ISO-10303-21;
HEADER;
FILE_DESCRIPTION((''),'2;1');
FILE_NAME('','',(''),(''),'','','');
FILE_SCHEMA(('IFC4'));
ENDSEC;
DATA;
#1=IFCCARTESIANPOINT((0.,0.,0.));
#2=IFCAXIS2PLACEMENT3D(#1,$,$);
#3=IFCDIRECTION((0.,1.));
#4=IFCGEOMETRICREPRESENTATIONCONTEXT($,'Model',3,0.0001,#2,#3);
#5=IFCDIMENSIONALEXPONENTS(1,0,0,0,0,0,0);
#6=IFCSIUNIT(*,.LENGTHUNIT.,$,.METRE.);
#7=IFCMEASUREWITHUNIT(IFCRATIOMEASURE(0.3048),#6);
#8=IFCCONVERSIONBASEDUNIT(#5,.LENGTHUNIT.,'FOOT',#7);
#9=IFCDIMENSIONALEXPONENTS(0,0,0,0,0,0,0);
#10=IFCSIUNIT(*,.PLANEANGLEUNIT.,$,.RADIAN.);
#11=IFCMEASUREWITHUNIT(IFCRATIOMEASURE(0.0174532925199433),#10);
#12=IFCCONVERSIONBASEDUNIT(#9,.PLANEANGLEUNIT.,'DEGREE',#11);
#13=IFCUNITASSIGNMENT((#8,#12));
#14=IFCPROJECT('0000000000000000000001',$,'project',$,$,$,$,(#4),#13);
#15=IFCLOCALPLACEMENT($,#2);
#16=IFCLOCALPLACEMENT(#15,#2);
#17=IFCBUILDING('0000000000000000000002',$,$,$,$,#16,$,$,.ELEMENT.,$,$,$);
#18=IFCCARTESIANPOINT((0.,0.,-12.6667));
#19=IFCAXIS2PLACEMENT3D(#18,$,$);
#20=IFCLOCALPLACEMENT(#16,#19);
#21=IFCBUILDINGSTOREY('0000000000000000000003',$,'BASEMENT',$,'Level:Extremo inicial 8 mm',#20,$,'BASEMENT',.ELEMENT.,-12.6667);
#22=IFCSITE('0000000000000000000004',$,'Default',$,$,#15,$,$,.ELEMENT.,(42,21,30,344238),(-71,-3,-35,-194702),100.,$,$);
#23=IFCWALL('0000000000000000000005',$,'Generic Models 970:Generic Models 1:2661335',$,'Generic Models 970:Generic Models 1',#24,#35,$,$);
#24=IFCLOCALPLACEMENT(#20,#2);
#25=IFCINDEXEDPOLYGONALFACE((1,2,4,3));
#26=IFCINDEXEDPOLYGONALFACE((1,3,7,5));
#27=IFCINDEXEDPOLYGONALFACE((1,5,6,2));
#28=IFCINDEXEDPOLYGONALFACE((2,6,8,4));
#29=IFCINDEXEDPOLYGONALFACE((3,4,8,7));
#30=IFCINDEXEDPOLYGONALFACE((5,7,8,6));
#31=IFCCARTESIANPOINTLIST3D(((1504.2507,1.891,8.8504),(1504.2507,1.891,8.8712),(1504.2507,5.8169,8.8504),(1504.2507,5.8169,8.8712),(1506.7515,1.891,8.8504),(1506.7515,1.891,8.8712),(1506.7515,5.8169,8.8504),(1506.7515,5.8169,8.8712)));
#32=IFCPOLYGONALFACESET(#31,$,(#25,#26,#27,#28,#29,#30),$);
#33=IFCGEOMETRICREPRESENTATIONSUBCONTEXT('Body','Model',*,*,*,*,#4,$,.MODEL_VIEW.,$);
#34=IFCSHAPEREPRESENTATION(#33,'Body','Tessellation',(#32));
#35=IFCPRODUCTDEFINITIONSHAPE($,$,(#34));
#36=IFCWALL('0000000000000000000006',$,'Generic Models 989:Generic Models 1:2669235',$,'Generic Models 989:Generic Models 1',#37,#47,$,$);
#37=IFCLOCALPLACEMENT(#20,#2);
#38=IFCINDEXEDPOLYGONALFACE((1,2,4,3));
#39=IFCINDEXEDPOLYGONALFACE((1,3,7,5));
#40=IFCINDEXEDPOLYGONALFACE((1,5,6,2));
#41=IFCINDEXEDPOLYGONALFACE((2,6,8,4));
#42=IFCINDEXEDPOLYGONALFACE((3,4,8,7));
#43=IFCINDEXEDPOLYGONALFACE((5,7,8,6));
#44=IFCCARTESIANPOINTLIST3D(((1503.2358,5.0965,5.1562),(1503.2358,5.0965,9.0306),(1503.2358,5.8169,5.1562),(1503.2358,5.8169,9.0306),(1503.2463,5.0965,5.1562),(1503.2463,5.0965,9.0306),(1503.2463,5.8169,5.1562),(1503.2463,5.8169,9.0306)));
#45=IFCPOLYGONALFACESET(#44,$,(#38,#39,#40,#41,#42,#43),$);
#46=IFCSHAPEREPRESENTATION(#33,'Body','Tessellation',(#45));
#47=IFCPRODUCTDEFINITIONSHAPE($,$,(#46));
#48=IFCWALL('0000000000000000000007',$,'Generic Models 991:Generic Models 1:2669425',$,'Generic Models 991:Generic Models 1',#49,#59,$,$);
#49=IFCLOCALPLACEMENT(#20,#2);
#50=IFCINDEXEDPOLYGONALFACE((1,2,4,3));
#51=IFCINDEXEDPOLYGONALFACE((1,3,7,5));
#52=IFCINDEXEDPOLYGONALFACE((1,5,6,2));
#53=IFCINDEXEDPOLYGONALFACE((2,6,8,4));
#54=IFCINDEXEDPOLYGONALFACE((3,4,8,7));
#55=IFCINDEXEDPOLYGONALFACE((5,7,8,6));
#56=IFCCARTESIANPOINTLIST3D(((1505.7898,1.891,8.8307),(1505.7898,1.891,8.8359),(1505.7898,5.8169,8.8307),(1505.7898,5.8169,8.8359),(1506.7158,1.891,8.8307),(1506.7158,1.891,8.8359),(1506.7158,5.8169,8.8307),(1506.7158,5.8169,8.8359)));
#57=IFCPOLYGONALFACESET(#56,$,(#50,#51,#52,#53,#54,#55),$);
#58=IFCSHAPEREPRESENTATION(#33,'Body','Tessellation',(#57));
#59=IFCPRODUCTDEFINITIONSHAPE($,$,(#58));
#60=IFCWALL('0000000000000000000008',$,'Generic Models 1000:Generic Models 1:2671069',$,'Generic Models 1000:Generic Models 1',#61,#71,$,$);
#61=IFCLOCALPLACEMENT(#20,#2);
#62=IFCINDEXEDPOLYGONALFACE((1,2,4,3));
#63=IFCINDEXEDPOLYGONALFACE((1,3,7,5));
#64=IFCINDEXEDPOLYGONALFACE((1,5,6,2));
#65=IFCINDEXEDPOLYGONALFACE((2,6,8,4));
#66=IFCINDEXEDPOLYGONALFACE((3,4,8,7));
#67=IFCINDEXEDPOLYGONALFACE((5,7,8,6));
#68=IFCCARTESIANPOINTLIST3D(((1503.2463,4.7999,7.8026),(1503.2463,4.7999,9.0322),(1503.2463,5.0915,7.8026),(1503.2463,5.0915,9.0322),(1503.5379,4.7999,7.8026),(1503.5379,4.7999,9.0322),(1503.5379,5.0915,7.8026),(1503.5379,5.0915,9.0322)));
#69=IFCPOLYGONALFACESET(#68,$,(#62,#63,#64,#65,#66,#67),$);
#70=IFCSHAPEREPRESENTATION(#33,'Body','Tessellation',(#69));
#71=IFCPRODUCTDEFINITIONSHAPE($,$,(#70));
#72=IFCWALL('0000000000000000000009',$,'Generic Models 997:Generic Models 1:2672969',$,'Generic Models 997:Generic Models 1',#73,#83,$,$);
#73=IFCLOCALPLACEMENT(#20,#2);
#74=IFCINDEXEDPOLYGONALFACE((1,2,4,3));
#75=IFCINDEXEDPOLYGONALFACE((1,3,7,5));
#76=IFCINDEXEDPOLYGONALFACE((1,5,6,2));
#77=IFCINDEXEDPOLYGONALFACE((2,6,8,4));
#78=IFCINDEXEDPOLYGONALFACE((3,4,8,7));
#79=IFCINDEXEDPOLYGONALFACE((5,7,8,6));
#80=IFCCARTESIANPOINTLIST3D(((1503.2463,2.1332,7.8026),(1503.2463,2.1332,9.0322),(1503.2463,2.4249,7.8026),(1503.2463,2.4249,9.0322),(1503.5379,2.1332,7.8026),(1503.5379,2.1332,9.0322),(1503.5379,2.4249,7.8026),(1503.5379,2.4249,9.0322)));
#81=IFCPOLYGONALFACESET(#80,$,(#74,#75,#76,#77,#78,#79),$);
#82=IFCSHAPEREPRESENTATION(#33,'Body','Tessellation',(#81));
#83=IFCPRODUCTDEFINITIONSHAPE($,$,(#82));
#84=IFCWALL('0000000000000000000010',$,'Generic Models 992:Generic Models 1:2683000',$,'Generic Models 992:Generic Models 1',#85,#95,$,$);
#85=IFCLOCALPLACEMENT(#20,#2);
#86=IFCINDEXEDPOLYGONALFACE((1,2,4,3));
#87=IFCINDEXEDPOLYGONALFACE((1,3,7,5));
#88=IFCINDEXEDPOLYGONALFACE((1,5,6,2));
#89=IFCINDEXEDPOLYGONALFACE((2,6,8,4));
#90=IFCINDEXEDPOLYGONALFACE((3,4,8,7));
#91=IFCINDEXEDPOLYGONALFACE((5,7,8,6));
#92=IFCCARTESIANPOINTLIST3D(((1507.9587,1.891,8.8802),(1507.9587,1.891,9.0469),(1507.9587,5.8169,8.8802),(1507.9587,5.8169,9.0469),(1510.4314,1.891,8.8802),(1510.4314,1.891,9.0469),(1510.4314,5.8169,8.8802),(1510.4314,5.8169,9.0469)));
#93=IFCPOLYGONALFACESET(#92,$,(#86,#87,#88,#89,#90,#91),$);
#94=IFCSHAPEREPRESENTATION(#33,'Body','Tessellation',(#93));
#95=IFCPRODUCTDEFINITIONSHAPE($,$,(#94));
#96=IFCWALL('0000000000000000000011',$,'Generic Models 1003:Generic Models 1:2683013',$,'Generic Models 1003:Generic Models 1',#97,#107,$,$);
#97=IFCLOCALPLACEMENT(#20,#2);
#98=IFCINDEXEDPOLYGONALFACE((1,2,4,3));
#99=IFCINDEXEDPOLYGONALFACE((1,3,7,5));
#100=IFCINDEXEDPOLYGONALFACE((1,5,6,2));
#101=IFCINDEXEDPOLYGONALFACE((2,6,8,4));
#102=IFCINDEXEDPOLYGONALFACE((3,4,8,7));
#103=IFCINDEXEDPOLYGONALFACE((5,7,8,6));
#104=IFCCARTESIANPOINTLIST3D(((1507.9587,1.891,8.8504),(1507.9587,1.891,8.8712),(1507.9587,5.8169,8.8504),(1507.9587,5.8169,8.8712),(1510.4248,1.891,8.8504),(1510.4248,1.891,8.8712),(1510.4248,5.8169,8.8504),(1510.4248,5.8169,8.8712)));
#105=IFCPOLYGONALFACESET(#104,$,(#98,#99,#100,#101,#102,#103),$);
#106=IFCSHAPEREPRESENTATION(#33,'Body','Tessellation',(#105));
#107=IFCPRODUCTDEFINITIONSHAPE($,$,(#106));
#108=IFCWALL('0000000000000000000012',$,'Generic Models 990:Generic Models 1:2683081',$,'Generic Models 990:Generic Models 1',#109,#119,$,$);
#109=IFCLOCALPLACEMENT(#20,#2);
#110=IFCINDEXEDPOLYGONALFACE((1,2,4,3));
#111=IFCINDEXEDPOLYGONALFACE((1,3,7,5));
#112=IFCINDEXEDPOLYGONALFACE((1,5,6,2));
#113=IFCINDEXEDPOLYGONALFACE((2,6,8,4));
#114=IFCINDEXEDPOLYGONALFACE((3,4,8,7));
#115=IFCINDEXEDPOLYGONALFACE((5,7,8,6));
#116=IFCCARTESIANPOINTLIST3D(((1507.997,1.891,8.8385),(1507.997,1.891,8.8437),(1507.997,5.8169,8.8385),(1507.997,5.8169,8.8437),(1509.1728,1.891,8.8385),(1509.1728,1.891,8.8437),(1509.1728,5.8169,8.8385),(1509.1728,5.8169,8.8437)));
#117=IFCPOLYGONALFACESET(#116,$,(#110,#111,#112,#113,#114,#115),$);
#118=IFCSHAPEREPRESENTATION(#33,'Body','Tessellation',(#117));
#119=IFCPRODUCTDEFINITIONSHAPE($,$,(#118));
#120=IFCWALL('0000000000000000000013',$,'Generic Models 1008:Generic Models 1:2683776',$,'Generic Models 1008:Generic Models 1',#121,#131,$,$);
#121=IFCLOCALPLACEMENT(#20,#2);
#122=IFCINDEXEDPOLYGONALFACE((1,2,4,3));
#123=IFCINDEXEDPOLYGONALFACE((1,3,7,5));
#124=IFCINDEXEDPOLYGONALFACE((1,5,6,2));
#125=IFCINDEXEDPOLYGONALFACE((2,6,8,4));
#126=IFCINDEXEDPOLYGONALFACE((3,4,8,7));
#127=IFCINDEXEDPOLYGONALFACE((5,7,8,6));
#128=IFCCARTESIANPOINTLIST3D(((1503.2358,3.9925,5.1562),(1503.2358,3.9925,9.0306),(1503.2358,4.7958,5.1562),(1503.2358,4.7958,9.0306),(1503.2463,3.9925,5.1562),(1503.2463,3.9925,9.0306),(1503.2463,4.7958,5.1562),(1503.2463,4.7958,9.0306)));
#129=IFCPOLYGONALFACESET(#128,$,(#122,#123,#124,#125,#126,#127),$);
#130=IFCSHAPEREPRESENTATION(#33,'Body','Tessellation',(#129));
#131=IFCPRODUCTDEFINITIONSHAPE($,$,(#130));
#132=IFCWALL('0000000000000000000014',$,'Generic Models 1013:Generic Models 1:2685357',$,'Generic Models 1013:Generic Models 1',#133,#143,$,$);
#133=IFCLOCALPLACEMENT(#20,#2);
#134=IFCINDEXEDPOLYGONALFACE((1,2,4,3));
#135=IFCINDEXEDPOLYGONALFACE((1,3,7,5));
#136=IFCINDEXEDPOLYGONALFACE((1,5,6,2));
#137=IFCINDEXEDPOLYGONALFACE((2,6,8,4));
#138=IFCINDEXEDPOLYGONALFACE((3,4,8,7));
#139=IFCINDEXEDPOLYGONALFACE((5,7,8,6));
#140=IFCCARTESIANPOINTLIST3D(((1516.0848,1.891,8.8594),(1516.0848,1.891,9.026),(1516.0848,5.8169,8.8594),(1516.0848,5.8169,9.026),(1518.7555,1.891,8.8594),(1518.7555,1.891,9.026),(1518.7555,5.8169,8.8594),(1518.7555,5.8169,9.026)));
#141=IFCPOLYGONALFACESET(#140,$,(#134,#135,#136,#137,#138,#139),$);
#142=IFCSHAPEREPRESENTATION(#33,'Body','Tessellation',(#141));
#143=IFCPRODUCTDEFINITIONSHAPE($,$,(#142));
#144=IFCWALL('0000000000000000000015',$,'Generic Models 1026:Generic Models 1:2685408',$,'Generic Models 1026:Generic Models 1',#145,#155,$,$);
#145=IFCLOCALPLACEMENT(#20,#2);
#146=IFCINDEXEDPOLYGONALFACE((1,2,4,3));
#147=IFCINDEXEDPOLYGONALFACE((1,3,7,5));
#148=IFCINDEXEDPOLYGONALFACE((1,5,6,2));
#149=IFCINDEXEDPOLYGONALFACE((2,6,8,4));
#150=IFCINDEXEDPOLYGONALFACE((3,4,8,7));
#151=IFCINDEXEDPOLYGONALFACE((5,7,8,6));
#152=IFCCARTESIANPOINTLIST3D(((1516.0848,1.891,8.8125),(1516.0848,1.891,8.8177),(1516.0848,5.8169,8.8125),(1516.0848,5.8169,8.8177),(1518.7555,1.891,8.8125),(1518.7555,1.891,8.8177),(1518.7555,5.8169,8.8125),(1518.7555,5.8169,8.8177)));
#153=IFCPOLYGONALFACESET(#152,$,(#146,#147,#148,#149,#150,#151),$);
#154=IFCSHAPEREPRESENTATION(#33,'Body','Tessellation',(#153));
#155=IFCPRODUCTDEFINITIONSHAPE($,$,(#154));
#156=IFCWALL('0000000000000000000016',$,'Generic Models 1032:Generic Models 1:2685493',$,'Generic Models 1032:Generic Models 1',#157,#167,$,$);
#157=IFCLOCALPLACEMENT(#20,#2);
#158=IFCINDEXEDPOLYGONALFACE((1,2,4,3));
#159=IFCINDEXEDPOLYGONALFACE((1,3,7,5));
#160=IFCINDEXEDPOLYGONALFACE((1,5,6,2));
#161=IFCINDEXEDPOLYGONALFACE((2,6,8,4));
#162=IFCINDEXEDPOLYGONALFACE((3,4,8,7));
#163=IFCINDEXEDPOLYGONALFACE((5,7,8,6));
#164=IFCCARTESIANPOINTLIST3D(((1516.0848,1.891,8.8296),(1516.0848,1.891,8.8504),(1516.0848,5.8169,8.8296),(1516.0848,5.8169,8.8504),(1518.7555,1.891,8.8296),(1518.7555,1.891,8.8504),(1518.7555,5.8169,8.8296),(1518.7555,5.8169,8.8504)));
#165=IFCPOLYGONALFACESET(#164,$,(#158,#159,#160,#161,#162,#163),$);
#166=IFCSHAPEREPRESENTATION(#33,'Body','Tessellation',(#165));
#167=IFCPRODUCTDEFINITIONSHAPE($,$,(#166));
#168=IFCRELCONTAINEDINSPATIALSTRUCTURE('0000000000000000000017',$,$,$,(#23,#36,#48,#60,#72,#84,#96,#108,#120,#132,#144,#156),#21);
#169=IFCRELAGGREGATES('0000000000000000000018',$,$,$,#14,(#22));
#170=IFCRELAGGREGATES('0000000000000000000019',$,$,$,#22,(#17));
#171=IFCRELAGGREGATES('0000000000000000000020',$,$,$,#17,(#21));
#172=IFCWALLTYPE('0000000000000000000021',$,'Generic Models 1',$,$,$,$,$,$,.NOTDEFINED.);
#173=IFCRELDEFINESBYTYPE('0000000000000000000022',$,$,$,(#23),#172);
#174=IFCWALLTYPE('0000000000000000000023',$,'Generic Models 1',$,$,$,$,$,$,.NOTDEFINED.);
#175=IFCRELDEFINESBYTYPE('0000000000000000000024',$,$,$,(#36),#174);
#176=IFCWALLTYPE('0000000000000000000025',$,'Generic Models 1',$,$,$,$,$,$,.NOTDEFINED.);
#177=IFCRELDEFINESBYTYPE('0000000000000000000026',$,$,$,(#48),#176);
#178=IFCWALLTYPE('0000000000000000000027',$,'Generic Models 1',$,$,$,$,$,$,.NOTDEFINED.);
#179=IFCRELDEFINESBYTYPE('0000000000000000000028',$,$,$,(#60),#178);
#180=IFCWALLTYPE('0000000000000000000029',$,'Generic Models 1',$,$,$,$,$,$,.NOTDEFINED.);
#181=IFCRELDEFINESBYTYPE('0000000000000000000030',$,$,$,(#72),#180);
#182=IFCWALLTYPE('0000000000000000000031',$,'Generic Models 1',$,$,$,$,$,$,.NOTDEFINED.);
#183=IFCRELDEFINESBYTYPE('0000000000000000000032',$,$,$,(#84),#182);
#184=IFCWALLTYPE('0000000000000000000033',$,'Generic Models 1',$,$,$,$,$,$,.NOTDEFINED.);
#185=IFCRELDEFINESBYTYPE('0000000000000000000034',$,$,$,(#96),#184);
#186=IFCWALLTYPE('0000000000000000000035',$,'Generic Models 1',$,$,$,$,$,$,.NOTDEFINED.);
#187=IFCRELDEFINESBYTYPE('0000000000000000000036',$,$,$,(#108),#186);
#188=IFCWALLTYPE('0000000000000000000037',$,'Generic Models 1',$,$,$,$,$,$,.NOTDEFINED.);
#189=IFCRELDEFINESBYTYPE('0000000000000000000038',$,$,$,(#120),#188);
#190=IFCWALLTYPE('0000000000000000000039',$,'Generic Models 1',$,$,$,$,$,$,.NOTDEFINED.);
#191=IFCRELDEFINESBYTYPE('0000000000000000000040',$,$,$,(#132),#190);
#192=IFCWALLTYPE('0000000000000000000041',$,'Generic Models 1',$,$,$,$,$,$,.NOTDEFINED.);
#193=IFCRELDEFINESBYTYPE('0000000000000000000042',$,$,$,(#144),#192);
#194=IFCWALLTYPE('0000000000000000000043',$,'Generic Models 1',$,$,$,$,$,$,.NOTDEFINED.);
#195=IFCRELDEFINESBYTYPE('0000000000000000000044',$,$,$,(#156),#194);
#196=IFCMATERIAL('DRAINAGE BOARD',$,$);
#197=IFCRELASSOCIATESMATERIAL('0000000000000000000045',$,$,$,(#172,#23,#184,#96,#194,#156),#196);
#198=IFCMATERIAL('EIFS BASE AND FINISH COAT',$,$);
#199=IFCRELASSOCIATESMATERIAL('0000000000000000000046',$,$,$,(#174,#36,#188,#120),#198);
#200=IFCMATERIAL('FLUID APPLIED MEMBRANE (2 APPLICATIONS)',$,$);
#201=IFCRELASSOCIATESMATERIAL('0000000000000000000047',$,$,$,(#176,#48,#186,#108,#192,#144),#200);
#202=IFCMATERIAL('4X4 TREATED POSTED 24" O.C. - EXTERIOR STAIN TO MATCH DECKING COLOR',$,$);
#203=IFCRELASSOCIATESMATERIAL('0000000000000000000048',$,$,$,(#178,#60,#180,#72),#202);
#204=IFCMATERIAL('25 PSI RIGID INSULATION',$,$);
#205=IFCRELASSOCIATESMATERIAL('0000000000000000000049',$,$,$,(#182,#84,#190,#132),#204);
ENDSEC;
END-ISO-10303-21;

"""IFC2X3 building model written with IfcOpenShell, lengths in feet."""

from ifc_helpers import new_model, entity, si_unit, converted_unit, direction, frame, frame_2d, origin, place, context, subcontext, project, spatial, rectangle, extrude, material, type_object, element, save


model = new_model("IFC2X3")

# Units and contexts
model_context = context("Model", 3, precision=0.0001, world=origin(), true_north=direction((0.0, 1.0)))
body_context = subcontext(model_context, "Body", "Model", "MODEL_VIEW")
ifc_project = project(units=[converted_unit("LENGTHUNIT", "FOOT", entity("IfcRatioMeasure", 0.3048), si_unit("LENGTHUNIT", "METRE"), dimensions=[1, 0, 0, 0, 0, 0, 0]), converted_unit("PLANEANGLEUNIT", "DEGREE", entity("IfcRatioMeasure", 0.0174532925199433), si_unit("PLANEANGLEUNIT", "RADIAN"), dimensions=[0, 0, 0, 0, 0, 0, 0])], contexts=[model_context])

# Site, building, storey
site_placement = place(None, origin())
site = spatial("IfcSite", under=ifc_project, at=site_placement, Name="Default", CompositionType="ELEMENT", RefLatitude=(42, 21, 30, 344238), RefLongitude=(-71, -3, -35, -194702), RefElevation=100.0)
building_placement = place(site_placement, origin())
building = spatial("IfcBuilding", under=site, at=building_placement, CompositionType="ELEMENT")
storey_placement = place(building_placement, frame((0.0, 0.0, -12.6667)))
storey = spatial("IfcBuildingStorey", under=building, at=storey_placement, Name="BASEMENT", ObjectType="Level:Extremo inicial 8 mm", LongName="BASEMENT", CompositionType="ELEMENT", Elevation=-12.6667)

# Shared definitions
ifc_material_1 = material(Name="25 PSI RIGID INSULATION")
ifc_material_2 = material(Name="FLUID APPLIED MEMBRANE (2 APPLICATIONS)")

# Walls
ifc_material_3 = material(Name="DRAINAGE BOARD")
wall_type_1 = type_object("IfcWallType", Name="Generic Models 1", PredefinedType="NOTDEFINED", material=ifc_material_3)
wall_1_placement = place(storey_placement, frame((1504.2507, 1.891, 8.8504), z_axis=(0.0, 0.0, 1.0), x_axis=(0.0, 1.0, 0.0)))
element("IfcWall", 1, at=wall_1_placement, inside=storey, type_object=wall_type_1, material=ifc_material_3, Name="Generic Models 970:Generic Models 1:2661335", ObjectType="Generic Models 970:Generic Models 1", context=body_context, shape_type="SweptSolid", body=[
    extrude(rectangle(XDim=3.9258, YDim=2.5007, at=frame_2d((0.0, 0.0), x_axis=(1.0, 0.0))), frame((1.9629, -1.2504, 0.0)), (0.0, 0.0, 1.0), 0.0208),
])
ifc_material_4 = material(Name="EIFS BASE AND FINISH COAT")
wall_type_2 = type_object("IfcWallType", Name="Generic Models 1", PredefinedType="NOTDEFINED", material=ifc_material_4)
wall_2_placement = place(storey_placement, frame((1503.2358, 5.0965, 5.1562), z_axis=(0.0, 0.0, 1.0), x_axis=(0.0, 1.0, 0.0)))
element("IfcWall", 2, at=wall_2_placement, inside=storey, type_object=wall_type_2, material=ifc_material_4, Name="Generic Models 989:Generic Models 1:2669235", ObjectType="Generic Models 989:Generic Models 1", context=body_context, shape_type="SweptSolid", body=[
    extrude(rectangle(XDim=0.7204, YDim=0.0104, at=frame_2d((0.0, 0.0), x_axis=(1.0, 0.0))), frame((0.3602, -0.0052, 0.0)), (0.0, 0.0, 1.0), 3.8744),
])
wall_type_3 = type_object("IfcWallType", Name="Generic Models 1", PredefinedType="NOTDEFINED", material=ifc_material_2)
wall_3_placement = place(storey_placement, frame((1505.7898, 1.891, 8.8307), z_axis=(0.0, 0.0, 1.0), x_axis=(0.0, 1.0, 0.0)))
element("IfcWall", 3, at=wall_3_placement, inside=storey, type_object=wall_type_3, material=ifc_material_2, Name="Generic Models 991:Generic Models 1:2669425", ObjectType="Generic Models 991:Generic Models 1", context=body_context, shape_type="SweptSolid", body=[
    extrude(rectangle(XDim=3.9258, YDim=0.9261, at=frame_2d((0.0, 0.0), x_axis=(1.0, 0.0))), frame((1.9629, -0.463, 0.0)), (0.0, 0.0, 1.0), 0.0052),
])
ifc_material_5 = material(Name="4X4 TREATED POSTED 24\" O.C. - EXTERIOR STAIN TO MATCH DECKING COLOR")
wall_type_4 = type_object("IfcWallType", Name="Generic Models 1", PredefinedType="NOTDEFINED", material=ifc_material_5)
wall_4_placement = place(storey_placement, frame((1503.2463, 4.7999, 7.8026)))
element("IfcWall", 4, at=wall_4_placement, inside=storey, type_object=wall_type_4, material=ifc_material_5, Name="Generic Models 1000:Generic Models 1:2671069", ObjectType="Generic Models 1000:Generic Models 1", context=body_context, shape_type="SweptSolid", body=[
    extrude(rectangle(XDim=0.2917, YDim=0.2917, at=frame_2d((0.0, 0.0), x_axis=(1.0, 0.0))), frame((0.1458, 0.1458, 0.0), z_axis=(0.0, 0.0, 1.0), x_axis=(0.0, 1.0, 0.0)), (0.0, 0.0, 1.0), 1.2295),
])
wall_type_5 = type_object("IfcWallType", Name="Generic Models 1", PredefinedType="NOTDEFINED", material=ifc_material_5)
wall_5_placement = place(storey_placement, frame((1503.2463, 2.1332, 7.8026)))
element("IfcWall", 5, at=wall_5_placement, inside=storey, type_object=wall_type_5, material=ifc_material_5, Name="Generic Models 997:Generic Models 1:2672969", ObjectType="Generic Models 997:Generic Models 1", context=body_context, shape_type="SweptSolid", body=[
    extrude(rectangle(XDim=0.2917, YDim=0.2917, at=frame_2d((0.0, 0.0), x_axis=(1.0, 0.0))), frame((0.1458, 0.1458, 0.0), z_axis=(0.0, 0.0, 1.0), x_axis=(0.0, -1.0, 0.0)), (0.0, 0.0, 1.0), 1.2295),
])
wall_type_6 = type_object("IfcWallType", Name="Generic Models 1", PredefinedType="NOTDEFINED", material=ifc_material_1)
wall_6_placement = place(storey_placement, frame((1507.9587, 1.891, 8.8802), z_axis=(0.0, 0.0, 1.0), x_axis=(0.0, 1.0, 0.0)))
element("IfcWall", 6, at=wall_6_placement, inside=storey, type_object=wall_type_6, material=ifc_material_1, Name="Generic Models 992:Generic Models 1:2683000", ObjectType="Generic Models 992:Generic Models 1", context=body_context, shape_type="SweptSolid", body=[
    extrude(rectangle(XDim=3.9258, YDim=2.4727, at=frame_2d((0.0, 0.0), x_axis=(1.0, 0.0))), frame((1.9629, -1.2364, 0.0)), (0.0, 0.0, 1.0), 0.1667),
])
wall_type_7 = type_object("IfcWallType", Name="Generic Models 1", PredefinedType="NOTDEFINED", material=ifc_material_3)
wall_7_placement = place(storey_placement, frame((1507.9587, 1.891, 8.8504), z_axis=(0.0, 0.0, 1.0), x_axis=(0.0, 1.0, 0.0)))
element("IfcWall", 7, at=wall_7_placement, inside=storey, type_object=wall_type_7, material=ifc_material_3, Name="Generic Models 1003:Generic Models 1:2683013", ObjectType="Generic Models 1003:Generic Models 1", context=body_context, shape_type="SweptSolid", body=[
    extrude(rectangle(XDim=3.9258, YDim=2.4661, at=frame_2d((0.0, 0.0), x_axis=(1.0, 0.0))), frame((1.9629, -1.2331, 0.0)), (0.0, 0.0, 1.0), 0.0208),
])
wall_type_8 = type_object("IfcWallType", Name="Generic Models 1", PredefinedType="NOTDEFINED", material=ifc_material_2)
wall_8_placement = place(storey_placement, frame((1507.997, 1.891, 8.8385), z_axis=(0.0, 0.0, 1.0), x_axis=(0.0, 1.0, 0.0)))
element("IfcWall", 8, at=wall_8_placement, inside=storey, type_object=wall_type_8, material=ifc_material_2, Name="Generic Models 990:Generic Models 1:2683081", ObjectType="Generic Models 990:Generic Models 1", context=body_context, shape_type="SweptSolid", body=[
    extrude(rectangle(XDim=3.9258, YDim=1.1758, at=frame_2d((0.0, 0.0), x_axis=(1.0, 0.0))), frame((1.9629, -0.5879, 0.0)), (0.0, 0.0, 1.0), 0.0052),
])
wall_type_9 = type_object("IfcWallType", Name="Generic Models 1", PredefinedType="NOTDEFINED", material=ifc_material_4)
wall_9_placement = place(storey_placement, frame((1503.2358, 3.9925, 5.1562), z_axis=(0.0, 0.0, 1.0), x_axis=(0.0, 1.0, 0.0)))
element("IfcWall", 9, at=wall_9_placement, inside=storey, type_object=wall_type_9, material=ifc_material_4, Name="Generic Models 1008:Generic Models 1:2683776", ObjectType="Generic Models 1008:Generic Models 1", context=body_context, shape_type="SweptSolid", body=[
    extrude(rectangle(XDim=0.8032, YDim=0.0104, at=frame_2d((0.0, 0.0), x_axis=(1.0, 0.0))), frame((0.4016, -0.0052, 0.0)), (0.0, 0.0, 1.0), 3.8744),
])
wall_type_10 = type_object("IfcWallType", Name="Generic Models 1", PredefinedType="NOTDEFINED", material=ifc_material_1)
wall_10_placement = place(storey_placement, frame((1516.0848, 1.891, 8.8594), z_axis=(0.0, 0.0, 1.0), x_axis=(0.0, 1.0, 0.0)))
element("IfcWall", 10, at=wall_10_placement, inside=storey, type_object=wall_type_10, material=ifc_material_1, Name="Generic Models 1013:Generic Models 1:2685357", ObjectType="Generic Models 1013:Generic Models 1", context=body_context, shape_type="SweptSolid", body=[
    extrude(rectangle(XDim=3.9258, YDim=2.6707, at=frame_2d((0.0, 0.0), x_axis=(1.0, 0.0))), frame((1.9629, -1.3353, 0.0)), (0.0, 0.0, 1.0), 0.1667),
])
wall_type_11 = type_object("IfcWallType", Name="Generic Models 1", PredefinedType="NOTDEFINED", material=ifc_material_2)
wall_11_placement = place(storey_placement, frame((1516.0848, 1.891, 8.8125), z_axis=(0.0, 0.0, 1.0), x_axis=(0.0, 1.0, 0.0)))
element("IfcWall", 11, at=wall_11_placement, inside=storey, type_object=wall_type_11, material=ifc_material_2, Name="Generic Models 1026:Generic Models 1:2685408", ObjectType="Generic Models 1026:Generic Models 1", context=body_context, shape_type="SweptSolid", body=[
    extrude(rectangle(XDim=3.9258, YDim=2.6707, at=frame_2d((0.0, 0.0), x_axis=(1.0, 0.0))), frame((1.9629, -1.3353, 0.0)), (0.0, 0.0, 1.0), 0.0052),
])
wall_type_12 = type_object("IfcWallType", Name="Generic Models 1", PredefinedType="NOTDEFINED", material=ifc_material_3)
wall_12_placement = place(storey_placement, frame((1516.0848, 1.891, 8.8296), z_axis=(0.0, 0.0, 1.0), x_axis=(0.0, 1.0, 0.0)))
element("IfcWall", 12, at=wall_12_placement, inside=storey, type_object=wall_type_12, material=ifc_material_3, Name="Generic Models 1032:Generic Models 1:2685493", ObjectType="Generic Models 1032:Generic Models 1", context=body_context, shape_type="SweptSolid", body=[
    extrude(rectangle(XDim=3.9258, YDim=2.6707, at=frame_2d((0.0, 0.0), x_axis=(1.0, 0.0))), frame((1.9629, -1.3353, 0.0)), (0.0, 0.0, 1.0), 0.0208),
])

save(model, "model.ifc")
